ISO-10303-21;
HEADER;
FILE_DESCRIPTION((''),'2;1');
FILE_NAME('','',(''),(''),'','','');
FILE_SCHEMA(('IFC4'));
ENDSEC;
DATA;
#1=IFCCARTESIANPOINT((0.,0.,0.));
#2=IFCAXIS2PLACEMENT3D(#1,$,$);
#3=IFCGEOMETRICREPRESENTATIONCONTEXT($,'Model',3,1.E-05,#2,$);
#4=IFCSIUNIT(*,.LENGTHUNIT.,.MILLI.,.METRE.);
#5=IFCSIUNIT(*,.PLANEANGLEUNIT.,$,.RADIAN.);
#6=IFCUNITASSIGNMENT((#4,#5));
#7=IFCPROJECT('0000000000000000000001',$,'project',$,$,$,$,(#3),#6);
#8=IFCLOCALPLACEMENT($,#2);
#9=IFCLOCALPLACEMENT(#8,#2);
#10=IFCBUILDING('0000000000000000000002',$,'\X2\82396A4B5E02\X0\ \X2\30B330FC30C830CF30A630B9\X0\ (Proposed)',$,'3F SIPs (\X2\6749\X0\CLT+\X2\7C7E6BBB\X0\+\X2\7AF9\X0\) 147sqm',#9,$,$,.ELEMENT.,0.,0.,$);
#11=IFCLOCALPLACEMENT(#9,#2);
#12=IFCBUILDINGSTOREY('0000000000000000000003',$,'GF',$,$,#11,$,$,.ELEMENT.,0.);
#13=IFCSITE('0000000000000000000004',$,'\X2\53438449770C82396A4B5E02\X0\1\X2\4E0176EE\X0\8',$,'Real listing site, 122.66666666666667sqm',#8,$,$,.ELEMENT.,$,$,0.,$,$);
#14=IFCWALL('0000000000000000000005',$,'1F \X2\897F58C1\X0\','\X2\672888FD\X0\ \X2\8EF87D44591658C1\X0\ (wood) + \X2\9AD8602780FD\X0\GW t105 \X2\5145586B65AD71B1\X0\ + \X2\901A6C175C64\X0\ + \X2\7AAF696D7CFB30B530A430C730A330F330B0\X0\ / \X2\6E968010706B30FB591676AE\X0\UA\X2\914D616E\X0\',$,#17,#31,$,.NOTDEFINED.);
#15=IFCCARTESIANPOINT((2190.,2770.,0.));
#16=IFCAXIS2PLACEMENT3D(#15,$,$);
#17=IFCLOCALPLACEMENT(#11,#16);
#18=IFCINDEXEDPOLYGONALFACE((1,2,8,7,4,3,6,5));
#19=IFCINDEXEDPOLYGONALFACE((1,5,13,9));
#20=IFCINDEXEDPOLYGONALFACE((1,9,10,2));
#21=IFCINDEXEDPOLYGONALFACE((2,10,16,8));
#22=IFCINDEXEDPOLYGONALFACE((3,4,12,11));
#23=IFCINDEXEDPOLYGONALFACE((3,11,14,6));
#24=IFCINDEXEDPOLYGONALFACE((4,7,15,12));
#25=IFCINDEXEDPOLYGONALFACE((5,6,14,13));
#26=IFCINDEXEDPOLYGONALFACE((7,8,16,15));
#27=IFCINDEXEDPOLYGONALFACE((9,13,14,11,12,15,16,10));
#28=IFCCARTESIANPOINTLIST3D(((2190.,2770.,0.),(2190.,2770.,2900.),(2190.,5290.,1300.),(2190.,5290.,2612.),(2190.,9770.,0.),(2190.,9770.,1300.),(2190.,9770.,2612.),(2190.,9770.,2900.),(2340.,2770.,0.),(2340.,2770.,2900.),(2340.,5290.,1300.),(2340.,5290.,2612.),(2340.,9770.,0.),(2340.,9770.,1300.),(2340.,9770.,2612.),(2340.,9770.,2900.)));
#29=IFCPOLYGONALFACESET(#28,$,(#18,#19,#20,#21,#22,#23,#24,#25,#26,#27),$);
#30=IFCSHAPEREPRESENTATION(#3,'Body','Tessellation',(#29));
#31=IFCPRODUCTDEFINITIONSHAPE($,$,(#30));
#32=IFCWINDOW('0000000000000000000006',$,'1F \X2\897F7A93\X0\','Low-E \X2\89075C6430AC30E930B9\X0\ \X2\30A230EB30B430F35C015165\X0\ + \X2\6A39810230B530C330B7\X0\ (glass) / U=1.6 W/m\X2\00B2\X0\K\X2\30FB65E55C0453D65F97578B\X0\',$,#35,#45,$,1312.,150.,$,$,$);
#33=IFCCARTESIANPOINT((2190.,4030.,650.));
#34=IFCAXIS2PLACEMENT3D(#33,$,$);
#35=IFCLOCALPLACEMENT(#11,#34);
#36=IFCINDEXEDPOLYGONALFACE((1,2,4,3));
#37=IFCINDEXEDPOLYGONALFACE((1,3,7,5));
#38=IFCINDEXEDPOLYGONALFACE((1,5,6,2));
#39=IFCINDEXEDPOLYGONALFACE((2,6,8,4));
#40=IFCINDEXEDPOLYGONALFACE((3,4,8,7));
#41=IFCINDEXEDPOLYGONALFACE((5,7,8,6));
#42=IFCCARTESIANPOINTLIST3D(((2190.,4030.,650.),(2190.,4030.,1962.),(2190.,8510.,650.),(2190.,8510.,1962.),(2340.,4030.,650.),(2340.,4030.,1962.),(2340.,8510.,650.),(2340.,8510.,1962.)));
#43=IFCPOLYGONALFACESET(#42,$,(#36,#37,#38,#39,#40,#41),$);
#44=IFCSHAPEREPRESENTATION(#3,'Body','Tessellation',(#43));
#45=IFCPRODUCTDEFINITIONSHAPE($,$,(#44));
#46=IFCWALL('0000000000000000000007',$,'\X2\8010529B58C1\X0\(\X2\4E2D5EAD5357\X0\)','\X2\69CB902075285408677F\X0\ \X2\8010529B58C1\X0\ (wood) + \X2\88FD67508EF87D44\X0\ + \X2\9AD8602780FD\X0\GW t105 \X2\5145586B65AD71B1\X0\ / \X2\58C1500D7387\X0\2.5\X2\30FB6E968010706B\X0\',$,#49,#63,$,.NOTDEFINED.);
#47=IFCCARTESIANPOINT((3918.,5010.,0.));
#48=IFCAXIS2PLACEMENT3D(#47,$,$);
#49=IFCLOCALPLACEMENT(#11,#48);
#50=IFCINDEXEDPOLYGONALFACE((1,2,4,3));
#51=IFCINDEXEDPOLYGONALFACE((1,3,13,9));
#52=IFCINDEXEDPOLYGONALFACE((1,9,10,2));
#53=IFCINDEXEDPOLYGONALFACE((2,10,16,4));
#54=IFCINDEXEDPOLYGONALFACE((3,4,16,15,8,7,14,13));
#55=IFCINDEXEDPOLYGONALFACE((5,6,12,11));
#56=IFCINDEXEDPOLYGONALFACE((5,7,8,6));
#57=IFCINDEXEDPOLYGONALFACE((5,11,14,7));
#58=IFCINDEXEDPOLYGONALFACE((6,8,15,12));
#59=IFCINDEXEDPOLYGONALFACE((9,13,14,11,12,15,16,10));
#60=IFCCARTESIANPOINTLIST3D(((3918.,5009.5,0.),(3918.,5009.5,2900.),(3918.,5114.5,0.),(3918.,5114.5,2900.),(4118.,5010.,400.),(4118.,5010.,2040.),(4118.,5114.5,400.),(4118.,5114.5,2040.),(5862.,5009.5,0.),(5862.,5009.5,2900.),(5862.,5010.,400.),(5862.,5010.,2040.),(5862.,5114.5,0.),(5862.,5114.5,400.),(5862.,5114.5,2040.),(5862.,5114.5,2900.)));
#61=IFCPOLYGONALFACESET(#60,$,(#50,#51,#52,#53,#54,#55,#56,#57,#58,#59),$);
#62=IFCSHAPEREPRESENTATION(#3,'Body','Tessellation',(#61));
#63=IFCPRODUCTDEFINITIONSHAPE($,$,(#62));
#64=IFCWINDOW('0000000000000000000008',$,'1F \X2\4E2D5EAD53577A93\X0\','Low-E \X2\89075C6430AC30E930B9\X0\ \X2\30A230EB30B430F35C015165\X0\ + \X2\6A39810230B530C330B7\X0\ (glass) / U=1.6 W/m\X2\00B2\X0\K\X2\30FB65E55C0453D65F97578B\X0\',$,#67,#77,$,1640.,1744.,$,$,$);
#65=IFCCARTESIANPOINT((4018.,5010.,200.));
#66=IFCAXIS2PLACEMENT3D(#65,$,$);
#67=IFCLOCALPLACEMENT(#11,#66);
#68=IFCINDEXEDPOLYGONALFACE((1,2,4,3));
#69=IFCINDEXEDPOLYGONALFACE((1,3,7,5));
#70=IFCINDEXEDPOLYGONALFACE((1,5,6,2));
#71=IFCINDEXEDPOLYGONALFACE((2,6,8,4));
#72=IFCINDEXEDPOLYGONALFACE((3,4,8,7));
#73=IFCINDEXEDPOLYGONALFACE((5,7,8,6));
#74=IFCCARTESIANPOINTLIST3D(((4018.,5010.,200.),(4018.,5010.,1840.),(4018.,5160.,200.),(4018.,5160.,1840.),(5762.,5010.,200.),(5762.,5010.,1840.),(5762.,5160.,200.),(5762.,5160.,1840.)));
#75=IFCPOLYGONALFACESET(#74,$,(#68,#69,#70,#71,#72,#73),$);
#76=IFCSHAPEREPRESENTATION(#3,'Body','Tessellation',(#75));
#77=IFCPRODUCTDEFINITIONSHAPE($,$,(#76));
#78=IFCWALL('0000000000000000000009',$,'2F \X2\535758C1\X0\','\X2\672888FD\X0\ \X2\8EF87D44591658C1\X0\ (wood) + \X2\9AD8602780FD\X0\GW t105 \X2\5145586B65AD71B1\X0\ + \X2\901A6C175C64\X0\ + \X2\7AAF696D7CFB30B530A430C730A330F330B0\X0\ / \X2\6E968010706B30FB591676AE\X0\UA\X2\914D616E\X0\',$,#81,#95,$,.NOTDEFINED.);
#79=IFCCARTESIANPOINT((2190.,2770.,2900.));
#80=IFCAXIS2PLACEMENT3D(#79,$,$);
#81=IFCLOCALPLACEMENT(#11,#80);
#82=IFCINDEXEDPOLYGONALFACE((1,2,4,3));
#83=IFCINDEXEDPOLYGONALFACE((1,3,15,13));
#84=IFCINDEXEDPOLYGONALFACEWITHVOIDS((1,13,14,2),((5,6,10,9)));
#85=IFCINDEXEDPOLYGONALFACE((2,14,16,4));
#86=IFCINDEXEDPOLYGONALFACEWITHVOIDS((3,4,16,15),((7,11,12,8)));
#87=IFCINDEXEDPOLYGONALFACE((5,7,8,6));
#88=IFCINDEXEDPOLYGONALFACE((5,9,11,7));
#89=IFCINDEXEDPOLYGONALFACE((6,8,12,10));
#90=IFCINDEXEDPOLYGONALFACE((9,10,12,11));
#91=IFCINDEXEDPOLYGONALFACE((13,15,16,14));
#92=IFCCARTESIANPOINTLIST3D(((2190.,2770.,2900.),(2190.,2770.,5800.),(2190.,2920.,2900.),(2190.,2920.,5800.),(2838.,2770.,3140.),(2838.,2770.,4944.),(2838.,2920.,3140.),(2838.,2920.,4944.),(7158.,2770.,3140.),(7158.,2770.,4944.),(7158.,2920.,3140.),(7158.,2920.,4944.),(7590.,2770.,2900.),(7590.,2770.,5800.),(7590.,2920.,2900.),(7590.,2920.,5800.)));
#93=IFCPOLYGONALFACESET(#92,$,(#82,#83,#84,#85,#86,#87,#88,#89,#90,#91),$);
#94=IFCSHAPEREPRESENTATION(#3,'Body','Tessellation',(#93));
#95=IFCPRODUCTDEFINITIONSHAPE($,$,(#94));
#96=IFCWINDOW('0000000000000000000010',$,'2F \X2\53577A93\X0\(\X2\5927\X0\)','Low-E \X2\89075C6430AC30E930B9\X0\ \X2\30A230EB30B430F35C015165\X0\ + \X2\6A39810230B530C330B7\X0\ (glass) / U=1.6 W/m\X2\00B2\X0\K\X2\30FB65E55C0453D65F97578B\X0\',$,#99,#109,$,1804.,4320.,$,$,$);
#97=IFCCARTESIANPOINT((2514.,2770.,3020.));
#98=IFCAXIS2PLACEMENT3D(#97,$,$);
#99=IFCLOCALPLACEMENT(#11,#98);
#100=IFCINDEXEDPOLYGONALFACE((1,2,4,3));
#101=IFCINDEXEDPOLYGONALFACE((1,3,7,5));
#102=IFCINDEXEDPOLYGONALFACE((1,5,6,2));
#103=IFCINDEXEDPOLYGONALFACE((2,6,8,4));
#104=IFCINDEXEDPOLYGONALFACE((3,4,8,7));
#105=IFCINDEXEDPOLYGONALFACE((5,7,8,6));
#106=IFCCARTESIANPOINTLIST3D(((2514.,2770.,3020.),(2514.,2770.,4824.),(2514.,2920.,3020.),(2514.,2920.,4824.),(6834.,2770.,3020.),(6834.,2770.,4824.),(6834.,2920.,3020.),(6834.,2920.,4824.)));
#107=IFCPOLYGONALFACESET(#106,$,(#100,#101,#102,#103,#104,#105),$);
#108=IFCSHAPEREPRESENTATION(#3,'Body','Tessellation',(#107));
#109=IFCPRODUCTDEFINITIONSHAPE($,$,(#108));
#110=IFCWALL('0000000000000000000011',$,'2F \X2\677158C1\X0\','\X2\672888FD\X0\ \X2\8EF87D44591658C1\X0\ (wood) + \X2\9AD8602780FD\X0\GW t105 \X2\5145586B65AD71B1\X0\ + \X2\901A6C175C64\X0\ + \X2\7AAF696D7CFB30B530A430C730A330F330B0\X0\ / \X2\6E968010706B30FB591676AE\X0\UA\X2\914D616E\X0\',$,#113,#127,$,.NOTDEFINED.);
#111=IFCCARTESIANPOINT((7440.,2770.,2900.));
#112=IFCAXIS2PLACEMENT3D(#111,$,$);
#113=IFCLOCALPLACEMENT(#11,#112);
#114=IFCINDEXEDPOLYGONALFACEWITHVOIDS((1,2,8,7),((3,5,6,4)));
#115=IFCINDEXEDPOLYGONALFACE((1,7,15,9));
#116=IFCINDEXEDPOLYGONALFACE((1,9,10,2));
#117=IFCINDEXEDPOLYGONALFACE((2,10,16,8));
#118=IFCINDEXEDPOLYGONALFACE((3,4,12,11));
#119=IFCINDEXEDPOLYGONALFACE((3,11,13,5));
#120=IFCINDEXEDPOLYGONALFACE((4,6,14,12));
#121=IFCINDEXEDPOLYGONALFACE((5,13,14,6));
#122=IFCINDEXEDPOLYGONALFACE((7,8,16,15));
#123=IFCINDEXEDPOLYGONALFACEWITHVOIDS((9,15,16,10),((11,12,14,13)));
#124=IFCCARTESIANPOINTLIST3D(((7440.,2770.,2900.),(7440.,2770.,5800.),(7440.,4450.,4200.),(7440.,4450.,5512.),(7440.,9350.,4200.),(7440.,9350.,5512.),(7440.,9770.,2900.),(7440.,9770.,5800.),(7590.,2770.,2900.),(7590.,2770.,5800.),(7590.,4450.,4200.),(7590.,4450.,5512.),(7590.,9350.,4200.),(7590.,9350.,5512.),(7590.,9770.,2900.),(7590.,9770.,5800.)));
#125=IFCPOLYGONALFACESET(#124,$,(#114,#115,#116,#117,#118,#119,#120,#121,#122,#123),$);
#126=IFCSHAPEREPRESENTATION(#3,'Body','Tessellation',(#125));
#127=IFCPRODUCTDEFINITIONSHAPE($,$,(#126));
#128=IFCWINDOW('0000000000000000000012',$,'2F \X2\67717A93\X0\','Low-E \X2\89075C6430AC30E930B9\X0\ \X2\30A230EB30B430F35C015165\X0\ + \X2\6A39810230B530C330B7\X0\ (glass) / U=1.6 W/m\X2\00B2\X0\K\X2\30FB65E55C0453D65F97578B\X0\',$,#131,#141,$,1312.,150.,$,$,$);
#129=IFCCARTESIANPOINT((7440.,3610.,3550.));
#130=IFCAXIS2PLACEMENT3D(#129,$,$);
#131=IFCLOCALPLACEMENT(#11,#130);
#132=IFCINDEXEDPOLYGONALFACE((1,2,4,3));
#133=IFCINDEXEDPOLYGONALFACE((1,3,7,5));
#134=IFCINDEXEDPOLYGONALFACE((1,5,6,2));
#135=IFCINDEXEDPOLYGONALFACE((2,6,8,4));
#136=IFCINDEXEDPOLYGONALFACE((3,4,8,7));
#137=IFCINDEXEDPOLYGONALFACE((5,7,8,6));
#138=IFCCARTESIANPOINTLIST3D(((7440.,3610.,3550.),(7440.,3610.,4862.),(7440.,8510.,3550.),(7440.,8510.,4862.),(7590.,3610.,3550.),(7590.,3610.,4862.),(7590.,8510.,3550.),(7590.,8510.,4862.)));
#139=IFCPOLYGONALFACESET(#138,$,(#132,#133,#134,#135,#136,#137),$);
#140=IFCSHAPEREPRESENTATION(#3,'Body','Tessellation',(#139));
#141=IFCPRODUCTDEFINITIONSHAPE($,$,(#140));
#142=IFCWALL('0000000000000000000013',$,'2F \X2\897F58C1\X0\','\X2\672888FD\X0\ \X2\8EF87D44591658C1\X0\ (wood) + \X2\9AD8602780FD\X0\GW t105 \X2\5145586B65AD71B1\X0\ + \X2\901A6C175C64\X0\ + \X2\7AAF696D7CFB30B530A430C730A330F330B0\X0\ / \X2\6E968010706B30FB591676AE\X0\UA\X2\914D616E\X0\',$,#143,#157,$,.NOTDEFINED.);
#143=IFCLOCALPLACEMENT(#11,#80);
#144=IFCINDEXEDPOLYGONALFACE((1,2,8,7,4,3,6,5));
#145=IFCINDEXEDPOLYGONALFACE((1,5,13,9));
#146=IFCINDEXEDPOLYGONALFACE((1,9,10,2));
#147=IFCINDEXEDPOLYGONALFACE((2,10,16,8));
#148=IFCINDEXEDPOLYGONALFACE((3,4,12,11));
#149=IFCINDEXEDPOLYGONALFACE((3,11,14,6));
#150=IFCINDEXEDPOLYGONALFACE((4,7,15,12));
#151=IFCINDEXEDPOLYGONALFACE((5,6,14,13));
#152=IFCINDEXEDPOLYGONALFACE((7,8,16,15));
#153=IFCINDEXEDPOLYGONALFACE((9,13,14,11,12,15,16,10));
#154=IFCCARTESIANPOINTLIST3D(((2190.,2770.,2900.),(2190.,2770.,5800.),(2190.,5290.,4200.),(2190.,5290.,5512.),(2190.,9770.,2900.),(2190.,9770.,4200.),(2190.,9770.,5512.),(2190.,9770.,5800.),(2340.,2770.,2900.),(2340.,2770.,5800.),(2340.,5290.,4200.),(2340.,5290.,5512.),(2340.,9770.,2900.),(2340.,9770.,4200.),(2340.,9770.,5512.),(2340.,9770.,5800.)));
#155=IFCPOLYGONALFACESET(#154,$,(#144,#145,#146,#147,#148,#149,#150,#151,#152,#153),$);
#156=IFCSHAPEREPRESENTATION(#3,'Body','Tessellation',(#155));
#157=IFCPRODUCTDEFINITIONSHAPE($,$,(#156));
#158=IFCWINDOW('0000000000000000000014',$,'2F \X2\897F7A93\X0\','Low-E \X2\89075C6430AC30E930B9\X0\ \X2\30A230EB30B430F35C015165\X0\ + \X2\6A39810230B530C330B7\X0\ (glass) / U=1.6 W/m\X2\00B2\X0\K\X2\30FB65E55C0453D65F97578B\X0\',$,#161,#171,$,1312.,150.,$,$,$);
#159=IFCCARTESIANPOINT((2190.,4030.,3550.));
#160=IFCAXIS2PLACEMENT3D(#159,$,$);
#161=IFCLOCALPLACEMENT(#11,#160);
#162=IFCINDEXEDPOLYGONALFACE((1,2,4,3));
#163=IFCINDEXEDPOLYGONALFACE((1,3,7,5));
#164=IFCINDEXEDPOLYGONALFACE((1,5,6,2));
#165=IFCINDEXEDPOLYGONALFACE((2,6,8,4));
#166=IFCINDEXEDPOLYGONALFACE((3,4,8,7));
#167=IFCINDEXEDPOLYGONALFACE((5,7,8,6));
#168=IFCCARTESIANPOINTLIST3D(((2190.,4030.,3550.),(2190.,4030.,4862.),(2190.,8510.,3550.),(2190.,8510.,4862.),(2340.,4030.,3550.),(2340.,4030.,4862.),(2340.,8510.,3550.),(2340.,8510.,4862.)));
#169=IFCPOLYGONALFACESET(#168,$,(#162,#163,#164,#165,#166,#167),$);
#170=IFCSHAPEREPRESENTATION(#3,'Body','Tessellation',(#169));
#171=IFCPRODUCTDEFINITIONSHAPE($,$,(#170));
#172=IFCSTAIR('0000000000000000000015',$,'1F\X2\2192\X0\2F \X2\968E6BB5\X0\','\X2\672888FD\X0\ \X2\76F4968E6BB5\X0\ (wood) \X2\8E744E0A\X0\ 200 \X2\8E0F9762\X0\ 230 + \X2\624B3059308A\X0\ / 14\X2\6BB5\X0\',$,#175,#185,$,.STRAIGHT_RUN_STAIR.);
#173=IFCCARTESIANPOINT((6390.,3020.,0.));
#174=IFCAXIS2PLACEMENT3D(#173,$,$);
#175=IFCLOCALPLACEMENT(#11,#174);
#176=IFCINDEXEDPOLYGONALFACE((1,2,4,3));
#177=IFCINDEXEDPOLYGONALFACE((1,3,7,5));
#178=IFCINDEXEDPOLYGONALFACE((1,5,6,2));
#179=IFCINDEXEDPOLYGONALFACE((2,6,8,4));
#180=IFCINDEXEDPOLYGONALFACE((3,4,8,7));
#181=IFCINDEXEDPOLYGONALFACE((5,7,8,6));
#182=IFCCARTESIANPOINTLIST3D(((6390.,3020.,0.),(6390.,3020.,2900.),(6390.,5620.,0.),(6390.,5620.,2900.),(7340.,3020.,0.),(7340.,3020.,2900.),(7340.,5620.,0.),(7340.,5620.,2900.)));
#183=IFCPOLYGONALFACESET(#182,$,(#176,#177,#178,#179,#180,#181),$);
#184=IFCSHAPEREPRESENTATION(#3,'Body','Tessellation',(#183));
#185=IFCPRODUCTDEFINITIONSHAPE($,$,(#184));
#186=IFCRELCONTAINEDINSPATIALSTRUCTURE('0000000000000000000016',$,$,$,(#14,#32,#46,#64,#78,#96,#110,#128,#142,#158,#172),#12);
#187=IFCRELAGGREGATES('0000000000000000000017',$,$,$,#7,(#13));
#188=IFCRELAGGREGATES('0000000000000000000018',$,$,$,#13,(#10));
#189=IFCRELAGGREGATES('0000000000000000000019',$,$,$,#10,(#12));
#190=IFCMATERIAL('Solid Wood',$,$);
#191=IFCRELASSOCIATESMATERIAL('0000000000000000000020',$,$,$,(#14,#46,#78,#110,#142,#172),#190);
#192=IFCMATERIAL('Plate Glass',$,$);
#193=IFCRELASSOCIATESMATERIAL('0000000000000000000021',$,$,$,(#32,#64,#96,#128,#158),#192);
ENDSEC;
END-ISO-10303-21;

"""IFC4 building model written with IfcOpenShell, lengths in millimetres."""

from ifc_helpers import new_model, si_unit, frame, frame_2d, origin, place, context, project, spatial, rectangle, extrude, material, element, fill, save


model = new_model("IFC4")

# Units and contexts
model_context = context("Model", 3, precision=1e-05, world=origin())
ifc_project = project(units=[si_unit("LENGTHUNIT", "METRE", prefix="MILLI"), si_unit("PLANEANGLEUNIT", "RADIAN")], contexts=[model_context])

# Site, building, storey
site_placement = place(None, origin())
site = spatial("IfcSite", under=ifc_project, at=site_placement, Name="千葉県船橋市1丁目8", ObjectType="Real listing site, 122.66666666666667sqm", CompositionType="ELEMENT", RefElevation=0.0)
building_placement = place(site_placement, origin())
building = spatial("IfcBuilding", under=site, at=building_placement, Name="船橋市 コートハウス (Proposed)", ObjectType="3F SIPs (杉CLT+籾殻+竹) 147sqm", CompositionType="ELEMENT", ElevationOfRefHeight=0.0, ElevationOfTerrain=0.0)
storey_placement = place(building_placement, origin())
storey = spatial("IfcBuildingStorey", under=building, at=storey_placement, Name="GF", CompositionType="ELEMENT", Elevation=0.0)

# Shared definitions
ifc_material_1 = material(Name="Solid Wood")

# Shared definitions
ifc_material_2 = material(Name="Plate Glass")

# Walls, openings, windows
wall_1_placement = place(storey_placement, frame((2190.0, 2770.0, 0.0)))
wall_1 = element("IfcWall", 1, at=wall_1_placement, inside=storey, material=ifc_material_1, Name="1F 西壁", Description="木製 軸組外壁 (wood) + 高性能GW t105 充填断熱 + 通気層 + 窯業系サイディング / 準耐火・外皮UA配慮", PredefinedType="NOTDEFINED", context=model_context, shape_type="SweptSolid", body=[
    extrude(rectangle(XDim=150.0, YDim=7000.0, at=frame_2d((75.0, 3500.0))), frame((2190.0, 2770.0, 0.0)), (0.0, 0.0, 1.0), 2900.0),
])
opening_1_placement = place(storey_placement, frame((2190.0, 4030.0, 650.0)))
opening_1 = element("IfcOpeningElement", 2, at=opening_1_placement, cuts=wall_1, PredefinedType="NOTDEFINED", context=model_context, shape_type="SweptSolid", body=[
    extrude(rectangle(XDim=150.0, YDim=4480.0, at=frame_2d((75.0, 2240.0))), frame((2190.0, 4030.0, 650.0)), (0.0, 0.0, 1.0), 1312.0),
])
window_1_placement = place(storey_placement, frame((2190.0, 4030.0, 650.0)))
window_1 = element("IfcWindow", 3, at=window_1_placement, inside=storey, material=ifc_material_2, Name="1F 西窓", Description="Low-E 複層ガラス アルゴン封入 + 樹脂サッシ (glass) / U=1.6 W/m²K・日射取得型", OverallHeight=1312.0, OverallWidth=150.0, context=model_context, shape_type="SweptSolid", body=[
    extrude(rectangle(XDim=150.0, YDim=4480.0, at=frame_2d((75.0, 2240.0))), frame((2190.0, 4030.0, 650.0)), (0.0, 0.0, 1.0), 1312.0),
])
fill(opening_1, window_1)
wall_2_placement = place(storey_placement, frame((3918.0, 5010.0, 0.0)))
wall_2 = element("IfcWall", 4, at=wall_2_placement, inside=storey, material=ifc_material_1, Name="耐力壁(中庭南)", Description="構造用合板 耐力壁 (wood) + 製材軸組 + 高性能GW t105 充填断熱 / 壁倍率2.5・準耐火", PredefinedType="NOTDEFINED", context=model_context, shape_type="SweptSolid", body=[
    extrude(rectangle(XDim=1944.0, YDim=105.0, at=frame_2d((972.0, 52.0))), frame((3918.0, 5010.0, 0.0)), (0.0, 0.0, 1.0), 2900.0),
])
opening_2_placement = place(storey_placement, frame((4018.0, 5010.0, 200.0)))
opening_2 = element("IfcOpeningElement", 5, at=opening_2_placement, cuts=wall_2, PredefinedType="NOTDEFINED", context=model_context, shape_type="SweptSolid", body=[
    extrude(rectangle(XDim=1744.0, YDim=150.0, at=frame_2d((872.0, 75.0))), frame((4018.0, 5010.0, 200.0)), (0.0, 0.0, 1.0), 1640.0),
])
window_2_placement = place(storey_placement, frame((4018.0, 5010.0, 200.0)))
window_2 = element("IfcWindow", 6, at=window_2_placement, inside=storey, material=ifc_material_2, Name="1F 中庭南窓", Description="Low-E 複層ガラス アルゴン封入 + 樹脂サッシ (glass) / U=1.6 W/m²K・日射取得型", OverallHeight=1640.0, OverallWidth=1744.0, context=model_context, shape_type="SweptSolid", body=[
    extrude(rectangle(XDim=1744.0, YDim=150.0, at=frame_2d((872.0, 75.0))), frame((4018.0, 5010.0, 200.0)), (0.0, 0.0, 1.0), 1640.0),
])
fill(opening_2, window_2)
wall_3_placement = place(storey_placement, frame((2190.0, 2770.0, 2900.0)))
wall_3 = element("IfcWall", 7, at=wall_3_placement, inside=storey, material=ifc_material_1, Name="2F 南壁", Description="木製 軸組外壁 (wood) + 高性能GW t105 充填断熱 + 通気層 + 窯業系サイディング / 準耐火・外皮UA配慮", PredefinedType="NOTDEFINED", context=model_context, shape_type="SweptSolid", body=[
    extrude(rectangle(XDim=5400.0, YDim=150.0, at=frame_2d((2700.0, 75.0))), frame((2190.0, 2770.0, 2900.0)), (0.0, 0.0, 1.0), 2900.0),
])
opening_3_placement = place(storey_placement, frame((2514.0, 2770.0, 3020.0)))
opening_3 = element("IfcOpeningElement", 8, at=opening_3_placement, cuts=wall_3, PredefinedType="NOTDEFINED", context=model_context, shape_type="SweptSolid", body=[
    extrude(rectangle(XDim=4320.0, YDim=150.0, at=frame_2d((2160.0, 75.0))), frame((2514.0, 2770.0, 3020.0)), (0.0, 0.0, 1.0), 1804.0),
])
window_3_placement = place(storey_placement, frame((2514.0, 2770.0, 3020.0)))
window_3 = element("IfcWindow", 9, at=window_3_placement, inside=storey, material=ifc_material_2, Name="2F 南窓(大)", Description="Low-E 複層ガラス アルゴン封入 + 樹脂サッシ (glass) / U=1.6 W/m²K・日射取得型", OverallHeight=1804.0, OverallWidth=4320.0, context=model_context, shape_type="SweptSolid", body=[
    extrude(rectangle(XDim=4320.0, YDim=150.0, at=frame_2d((2160.0, 75.0))), frame((2514.0, 2770.0, 3020.0)), (0.0, 0.0, 1.0), 1804.0),
])
fill(opening_3, window_3)
wall_4_placement = place(storey_placement, frame((7440.0, 2770.0, 2900.0)))
wall_4 = element("IfcWall", 10, at=wall_4_placement, inside=storey, material=ifc_material_1, Name="2F 東壁", Description="木製 軸組外壁 (wood) + 高性能GW t105 充填断熱 + 通気層 + 窯業系サイディング / 準耐火・外皮UA配慮", PredefinedType="NOTDEFINED", context=model_context, shape_type="SweptSolid", body=[
    extrude(rectangle(XDim=150.0, YDim=7000.0, at=frame_2d((75.0, 3500.0))), frame((7440.0, 2770.0, 2900.0)), (0.0, 0.0, 1.0), 2900.0),
])
opening_4_placement = place(storey_placement, frame((7440.0, 3610.0, 3550.0)))
opening_4 = element("IfcOpeningElement", 11, at=opening_4_placement, cuts=wall_4, PredefinedType="NOTDEFINED", context=model_context, shape_type="SweptSolid", body=[
    extrude(rectangle(XDim=150.0, YDim=4900.0, at=frame_2d((75.0, 2450.0))), frame((7440.0, 3610.0, 3550.0)), (0.0, 0.0, 1.0), 1312.0),
])
window_4_placement = place(storey_placement, frame((7440.0, 3610.0, 3550.0)))
window_4 = element("IfcWindow", 12, at=window_4_placement, inside=storey, material=ifc_material_2, Name="2F 東窓", Description="Low-E 複層ガラス アルゴン封入 + 樹脂サッシ (glass) / U=1.6 W/m²K・日射取得型", OverallHeight=1312.0, OverallWidth=150.0, context=model_context, shape_type="SweptSolid", body=[
    extrude(rectangle(XDim=150.0, YDim=4900.0, at=frame_2d((75.0, 2450.0))), frame((7440.0, 3610.0, 3550.0)), (0.0, 0.0, 1.0), 1312.0),
])
fill(opening_4, window_4)
wall_5_placement = place(storey_placement, frame((2190.0, 2770.0, 2900.0)))
wall_5 = element("IfcWall", 13, at=wall_5_placement, inside=storey, material=ifc_material_1, Name="2F 西壁", Description="木製 軸組外壁 (wood) + 高性能GW t105 充填断熱 + 通気層 + 窯業系サイディング / 準耐火・外皮UA配慮", PredefinedType="NOTDEFINED", context=model_context, shape_type="SweptSolid", body=[
    extrude(rectangle(XDim=150.0, YDim=7000.0, at=frame_2d((75.0, 3500.0))), frame((2190.0, 2770.0, 2900.0)), (0.0, 0.0, 1.0), 2900.0),
])
opening_5_placement = place(storey_placement, frame((2190.0, 4030.0, 3550.0)))
opening_5 = element("IfcOpeningElement", 14, at=opening_5_placement, cuts=wall_5, PredefinedType="NOTDEFINED", context=model_context, shape_type="SweptSolid", body=[
    extrude(rectangle(XDim=150.0, YDim=4480.0, at=frame_2d((75.0, 2240.0))), frame((2190.0, 4030.0, 3550.0)), (0.0, 0.0, 1.0), 1312.0),
])
window_5_placement = place(storey_placement, frame((2190.0, 4030.0, 3550.0)))
window_5 = element("IfcWindow", 15, at=window_5_placement, inside=storey, material=ifc_material_2, Name="2F 西窓", Description="Low-E 複層ガラス アルゴン封入 + 樹脂サッシ (glass) / U=1.6 W/m²K・日射取得型", OverallHeight=1312.0, OverallWidth=150.0, context=model_context, shape_type="SweptSolid", body=[
    extrude(rectangle(XDim=150.0, YDim=4480.0, at=frame_2d((75.0, 2240.0))), frame((2190.0, 4030.0, 3550.0)), (0.0, 0.0, 1.0), 1312.0),
])
fill(opening_5, window_5)

# Stair
stair_1_placement = place(storey_placement, frame((6390.0, 3020.0, 0.0)))
element("IfcStair", 16, at=stair_1_placement, inside=storey, material=ifc_material_1, Name="1F→2F 階段", Description="木製 直階段 (wood) 蹴上 200 踏面 230 + 手すり / 14段", PredefinedType="STRAIGHT_RUN_STAIR", context=model_context, shape_type="SweptSolid", body=[
    extrude(rectangle(XDim=950.0, YDim=2600.0, at=frame_2d((475.0, 1300.0))), frame((6390.0, 3020.0, 0.0)), (0.0, 0.0, 1.0), 2900.0),
])

save(model, "model.ifc")
